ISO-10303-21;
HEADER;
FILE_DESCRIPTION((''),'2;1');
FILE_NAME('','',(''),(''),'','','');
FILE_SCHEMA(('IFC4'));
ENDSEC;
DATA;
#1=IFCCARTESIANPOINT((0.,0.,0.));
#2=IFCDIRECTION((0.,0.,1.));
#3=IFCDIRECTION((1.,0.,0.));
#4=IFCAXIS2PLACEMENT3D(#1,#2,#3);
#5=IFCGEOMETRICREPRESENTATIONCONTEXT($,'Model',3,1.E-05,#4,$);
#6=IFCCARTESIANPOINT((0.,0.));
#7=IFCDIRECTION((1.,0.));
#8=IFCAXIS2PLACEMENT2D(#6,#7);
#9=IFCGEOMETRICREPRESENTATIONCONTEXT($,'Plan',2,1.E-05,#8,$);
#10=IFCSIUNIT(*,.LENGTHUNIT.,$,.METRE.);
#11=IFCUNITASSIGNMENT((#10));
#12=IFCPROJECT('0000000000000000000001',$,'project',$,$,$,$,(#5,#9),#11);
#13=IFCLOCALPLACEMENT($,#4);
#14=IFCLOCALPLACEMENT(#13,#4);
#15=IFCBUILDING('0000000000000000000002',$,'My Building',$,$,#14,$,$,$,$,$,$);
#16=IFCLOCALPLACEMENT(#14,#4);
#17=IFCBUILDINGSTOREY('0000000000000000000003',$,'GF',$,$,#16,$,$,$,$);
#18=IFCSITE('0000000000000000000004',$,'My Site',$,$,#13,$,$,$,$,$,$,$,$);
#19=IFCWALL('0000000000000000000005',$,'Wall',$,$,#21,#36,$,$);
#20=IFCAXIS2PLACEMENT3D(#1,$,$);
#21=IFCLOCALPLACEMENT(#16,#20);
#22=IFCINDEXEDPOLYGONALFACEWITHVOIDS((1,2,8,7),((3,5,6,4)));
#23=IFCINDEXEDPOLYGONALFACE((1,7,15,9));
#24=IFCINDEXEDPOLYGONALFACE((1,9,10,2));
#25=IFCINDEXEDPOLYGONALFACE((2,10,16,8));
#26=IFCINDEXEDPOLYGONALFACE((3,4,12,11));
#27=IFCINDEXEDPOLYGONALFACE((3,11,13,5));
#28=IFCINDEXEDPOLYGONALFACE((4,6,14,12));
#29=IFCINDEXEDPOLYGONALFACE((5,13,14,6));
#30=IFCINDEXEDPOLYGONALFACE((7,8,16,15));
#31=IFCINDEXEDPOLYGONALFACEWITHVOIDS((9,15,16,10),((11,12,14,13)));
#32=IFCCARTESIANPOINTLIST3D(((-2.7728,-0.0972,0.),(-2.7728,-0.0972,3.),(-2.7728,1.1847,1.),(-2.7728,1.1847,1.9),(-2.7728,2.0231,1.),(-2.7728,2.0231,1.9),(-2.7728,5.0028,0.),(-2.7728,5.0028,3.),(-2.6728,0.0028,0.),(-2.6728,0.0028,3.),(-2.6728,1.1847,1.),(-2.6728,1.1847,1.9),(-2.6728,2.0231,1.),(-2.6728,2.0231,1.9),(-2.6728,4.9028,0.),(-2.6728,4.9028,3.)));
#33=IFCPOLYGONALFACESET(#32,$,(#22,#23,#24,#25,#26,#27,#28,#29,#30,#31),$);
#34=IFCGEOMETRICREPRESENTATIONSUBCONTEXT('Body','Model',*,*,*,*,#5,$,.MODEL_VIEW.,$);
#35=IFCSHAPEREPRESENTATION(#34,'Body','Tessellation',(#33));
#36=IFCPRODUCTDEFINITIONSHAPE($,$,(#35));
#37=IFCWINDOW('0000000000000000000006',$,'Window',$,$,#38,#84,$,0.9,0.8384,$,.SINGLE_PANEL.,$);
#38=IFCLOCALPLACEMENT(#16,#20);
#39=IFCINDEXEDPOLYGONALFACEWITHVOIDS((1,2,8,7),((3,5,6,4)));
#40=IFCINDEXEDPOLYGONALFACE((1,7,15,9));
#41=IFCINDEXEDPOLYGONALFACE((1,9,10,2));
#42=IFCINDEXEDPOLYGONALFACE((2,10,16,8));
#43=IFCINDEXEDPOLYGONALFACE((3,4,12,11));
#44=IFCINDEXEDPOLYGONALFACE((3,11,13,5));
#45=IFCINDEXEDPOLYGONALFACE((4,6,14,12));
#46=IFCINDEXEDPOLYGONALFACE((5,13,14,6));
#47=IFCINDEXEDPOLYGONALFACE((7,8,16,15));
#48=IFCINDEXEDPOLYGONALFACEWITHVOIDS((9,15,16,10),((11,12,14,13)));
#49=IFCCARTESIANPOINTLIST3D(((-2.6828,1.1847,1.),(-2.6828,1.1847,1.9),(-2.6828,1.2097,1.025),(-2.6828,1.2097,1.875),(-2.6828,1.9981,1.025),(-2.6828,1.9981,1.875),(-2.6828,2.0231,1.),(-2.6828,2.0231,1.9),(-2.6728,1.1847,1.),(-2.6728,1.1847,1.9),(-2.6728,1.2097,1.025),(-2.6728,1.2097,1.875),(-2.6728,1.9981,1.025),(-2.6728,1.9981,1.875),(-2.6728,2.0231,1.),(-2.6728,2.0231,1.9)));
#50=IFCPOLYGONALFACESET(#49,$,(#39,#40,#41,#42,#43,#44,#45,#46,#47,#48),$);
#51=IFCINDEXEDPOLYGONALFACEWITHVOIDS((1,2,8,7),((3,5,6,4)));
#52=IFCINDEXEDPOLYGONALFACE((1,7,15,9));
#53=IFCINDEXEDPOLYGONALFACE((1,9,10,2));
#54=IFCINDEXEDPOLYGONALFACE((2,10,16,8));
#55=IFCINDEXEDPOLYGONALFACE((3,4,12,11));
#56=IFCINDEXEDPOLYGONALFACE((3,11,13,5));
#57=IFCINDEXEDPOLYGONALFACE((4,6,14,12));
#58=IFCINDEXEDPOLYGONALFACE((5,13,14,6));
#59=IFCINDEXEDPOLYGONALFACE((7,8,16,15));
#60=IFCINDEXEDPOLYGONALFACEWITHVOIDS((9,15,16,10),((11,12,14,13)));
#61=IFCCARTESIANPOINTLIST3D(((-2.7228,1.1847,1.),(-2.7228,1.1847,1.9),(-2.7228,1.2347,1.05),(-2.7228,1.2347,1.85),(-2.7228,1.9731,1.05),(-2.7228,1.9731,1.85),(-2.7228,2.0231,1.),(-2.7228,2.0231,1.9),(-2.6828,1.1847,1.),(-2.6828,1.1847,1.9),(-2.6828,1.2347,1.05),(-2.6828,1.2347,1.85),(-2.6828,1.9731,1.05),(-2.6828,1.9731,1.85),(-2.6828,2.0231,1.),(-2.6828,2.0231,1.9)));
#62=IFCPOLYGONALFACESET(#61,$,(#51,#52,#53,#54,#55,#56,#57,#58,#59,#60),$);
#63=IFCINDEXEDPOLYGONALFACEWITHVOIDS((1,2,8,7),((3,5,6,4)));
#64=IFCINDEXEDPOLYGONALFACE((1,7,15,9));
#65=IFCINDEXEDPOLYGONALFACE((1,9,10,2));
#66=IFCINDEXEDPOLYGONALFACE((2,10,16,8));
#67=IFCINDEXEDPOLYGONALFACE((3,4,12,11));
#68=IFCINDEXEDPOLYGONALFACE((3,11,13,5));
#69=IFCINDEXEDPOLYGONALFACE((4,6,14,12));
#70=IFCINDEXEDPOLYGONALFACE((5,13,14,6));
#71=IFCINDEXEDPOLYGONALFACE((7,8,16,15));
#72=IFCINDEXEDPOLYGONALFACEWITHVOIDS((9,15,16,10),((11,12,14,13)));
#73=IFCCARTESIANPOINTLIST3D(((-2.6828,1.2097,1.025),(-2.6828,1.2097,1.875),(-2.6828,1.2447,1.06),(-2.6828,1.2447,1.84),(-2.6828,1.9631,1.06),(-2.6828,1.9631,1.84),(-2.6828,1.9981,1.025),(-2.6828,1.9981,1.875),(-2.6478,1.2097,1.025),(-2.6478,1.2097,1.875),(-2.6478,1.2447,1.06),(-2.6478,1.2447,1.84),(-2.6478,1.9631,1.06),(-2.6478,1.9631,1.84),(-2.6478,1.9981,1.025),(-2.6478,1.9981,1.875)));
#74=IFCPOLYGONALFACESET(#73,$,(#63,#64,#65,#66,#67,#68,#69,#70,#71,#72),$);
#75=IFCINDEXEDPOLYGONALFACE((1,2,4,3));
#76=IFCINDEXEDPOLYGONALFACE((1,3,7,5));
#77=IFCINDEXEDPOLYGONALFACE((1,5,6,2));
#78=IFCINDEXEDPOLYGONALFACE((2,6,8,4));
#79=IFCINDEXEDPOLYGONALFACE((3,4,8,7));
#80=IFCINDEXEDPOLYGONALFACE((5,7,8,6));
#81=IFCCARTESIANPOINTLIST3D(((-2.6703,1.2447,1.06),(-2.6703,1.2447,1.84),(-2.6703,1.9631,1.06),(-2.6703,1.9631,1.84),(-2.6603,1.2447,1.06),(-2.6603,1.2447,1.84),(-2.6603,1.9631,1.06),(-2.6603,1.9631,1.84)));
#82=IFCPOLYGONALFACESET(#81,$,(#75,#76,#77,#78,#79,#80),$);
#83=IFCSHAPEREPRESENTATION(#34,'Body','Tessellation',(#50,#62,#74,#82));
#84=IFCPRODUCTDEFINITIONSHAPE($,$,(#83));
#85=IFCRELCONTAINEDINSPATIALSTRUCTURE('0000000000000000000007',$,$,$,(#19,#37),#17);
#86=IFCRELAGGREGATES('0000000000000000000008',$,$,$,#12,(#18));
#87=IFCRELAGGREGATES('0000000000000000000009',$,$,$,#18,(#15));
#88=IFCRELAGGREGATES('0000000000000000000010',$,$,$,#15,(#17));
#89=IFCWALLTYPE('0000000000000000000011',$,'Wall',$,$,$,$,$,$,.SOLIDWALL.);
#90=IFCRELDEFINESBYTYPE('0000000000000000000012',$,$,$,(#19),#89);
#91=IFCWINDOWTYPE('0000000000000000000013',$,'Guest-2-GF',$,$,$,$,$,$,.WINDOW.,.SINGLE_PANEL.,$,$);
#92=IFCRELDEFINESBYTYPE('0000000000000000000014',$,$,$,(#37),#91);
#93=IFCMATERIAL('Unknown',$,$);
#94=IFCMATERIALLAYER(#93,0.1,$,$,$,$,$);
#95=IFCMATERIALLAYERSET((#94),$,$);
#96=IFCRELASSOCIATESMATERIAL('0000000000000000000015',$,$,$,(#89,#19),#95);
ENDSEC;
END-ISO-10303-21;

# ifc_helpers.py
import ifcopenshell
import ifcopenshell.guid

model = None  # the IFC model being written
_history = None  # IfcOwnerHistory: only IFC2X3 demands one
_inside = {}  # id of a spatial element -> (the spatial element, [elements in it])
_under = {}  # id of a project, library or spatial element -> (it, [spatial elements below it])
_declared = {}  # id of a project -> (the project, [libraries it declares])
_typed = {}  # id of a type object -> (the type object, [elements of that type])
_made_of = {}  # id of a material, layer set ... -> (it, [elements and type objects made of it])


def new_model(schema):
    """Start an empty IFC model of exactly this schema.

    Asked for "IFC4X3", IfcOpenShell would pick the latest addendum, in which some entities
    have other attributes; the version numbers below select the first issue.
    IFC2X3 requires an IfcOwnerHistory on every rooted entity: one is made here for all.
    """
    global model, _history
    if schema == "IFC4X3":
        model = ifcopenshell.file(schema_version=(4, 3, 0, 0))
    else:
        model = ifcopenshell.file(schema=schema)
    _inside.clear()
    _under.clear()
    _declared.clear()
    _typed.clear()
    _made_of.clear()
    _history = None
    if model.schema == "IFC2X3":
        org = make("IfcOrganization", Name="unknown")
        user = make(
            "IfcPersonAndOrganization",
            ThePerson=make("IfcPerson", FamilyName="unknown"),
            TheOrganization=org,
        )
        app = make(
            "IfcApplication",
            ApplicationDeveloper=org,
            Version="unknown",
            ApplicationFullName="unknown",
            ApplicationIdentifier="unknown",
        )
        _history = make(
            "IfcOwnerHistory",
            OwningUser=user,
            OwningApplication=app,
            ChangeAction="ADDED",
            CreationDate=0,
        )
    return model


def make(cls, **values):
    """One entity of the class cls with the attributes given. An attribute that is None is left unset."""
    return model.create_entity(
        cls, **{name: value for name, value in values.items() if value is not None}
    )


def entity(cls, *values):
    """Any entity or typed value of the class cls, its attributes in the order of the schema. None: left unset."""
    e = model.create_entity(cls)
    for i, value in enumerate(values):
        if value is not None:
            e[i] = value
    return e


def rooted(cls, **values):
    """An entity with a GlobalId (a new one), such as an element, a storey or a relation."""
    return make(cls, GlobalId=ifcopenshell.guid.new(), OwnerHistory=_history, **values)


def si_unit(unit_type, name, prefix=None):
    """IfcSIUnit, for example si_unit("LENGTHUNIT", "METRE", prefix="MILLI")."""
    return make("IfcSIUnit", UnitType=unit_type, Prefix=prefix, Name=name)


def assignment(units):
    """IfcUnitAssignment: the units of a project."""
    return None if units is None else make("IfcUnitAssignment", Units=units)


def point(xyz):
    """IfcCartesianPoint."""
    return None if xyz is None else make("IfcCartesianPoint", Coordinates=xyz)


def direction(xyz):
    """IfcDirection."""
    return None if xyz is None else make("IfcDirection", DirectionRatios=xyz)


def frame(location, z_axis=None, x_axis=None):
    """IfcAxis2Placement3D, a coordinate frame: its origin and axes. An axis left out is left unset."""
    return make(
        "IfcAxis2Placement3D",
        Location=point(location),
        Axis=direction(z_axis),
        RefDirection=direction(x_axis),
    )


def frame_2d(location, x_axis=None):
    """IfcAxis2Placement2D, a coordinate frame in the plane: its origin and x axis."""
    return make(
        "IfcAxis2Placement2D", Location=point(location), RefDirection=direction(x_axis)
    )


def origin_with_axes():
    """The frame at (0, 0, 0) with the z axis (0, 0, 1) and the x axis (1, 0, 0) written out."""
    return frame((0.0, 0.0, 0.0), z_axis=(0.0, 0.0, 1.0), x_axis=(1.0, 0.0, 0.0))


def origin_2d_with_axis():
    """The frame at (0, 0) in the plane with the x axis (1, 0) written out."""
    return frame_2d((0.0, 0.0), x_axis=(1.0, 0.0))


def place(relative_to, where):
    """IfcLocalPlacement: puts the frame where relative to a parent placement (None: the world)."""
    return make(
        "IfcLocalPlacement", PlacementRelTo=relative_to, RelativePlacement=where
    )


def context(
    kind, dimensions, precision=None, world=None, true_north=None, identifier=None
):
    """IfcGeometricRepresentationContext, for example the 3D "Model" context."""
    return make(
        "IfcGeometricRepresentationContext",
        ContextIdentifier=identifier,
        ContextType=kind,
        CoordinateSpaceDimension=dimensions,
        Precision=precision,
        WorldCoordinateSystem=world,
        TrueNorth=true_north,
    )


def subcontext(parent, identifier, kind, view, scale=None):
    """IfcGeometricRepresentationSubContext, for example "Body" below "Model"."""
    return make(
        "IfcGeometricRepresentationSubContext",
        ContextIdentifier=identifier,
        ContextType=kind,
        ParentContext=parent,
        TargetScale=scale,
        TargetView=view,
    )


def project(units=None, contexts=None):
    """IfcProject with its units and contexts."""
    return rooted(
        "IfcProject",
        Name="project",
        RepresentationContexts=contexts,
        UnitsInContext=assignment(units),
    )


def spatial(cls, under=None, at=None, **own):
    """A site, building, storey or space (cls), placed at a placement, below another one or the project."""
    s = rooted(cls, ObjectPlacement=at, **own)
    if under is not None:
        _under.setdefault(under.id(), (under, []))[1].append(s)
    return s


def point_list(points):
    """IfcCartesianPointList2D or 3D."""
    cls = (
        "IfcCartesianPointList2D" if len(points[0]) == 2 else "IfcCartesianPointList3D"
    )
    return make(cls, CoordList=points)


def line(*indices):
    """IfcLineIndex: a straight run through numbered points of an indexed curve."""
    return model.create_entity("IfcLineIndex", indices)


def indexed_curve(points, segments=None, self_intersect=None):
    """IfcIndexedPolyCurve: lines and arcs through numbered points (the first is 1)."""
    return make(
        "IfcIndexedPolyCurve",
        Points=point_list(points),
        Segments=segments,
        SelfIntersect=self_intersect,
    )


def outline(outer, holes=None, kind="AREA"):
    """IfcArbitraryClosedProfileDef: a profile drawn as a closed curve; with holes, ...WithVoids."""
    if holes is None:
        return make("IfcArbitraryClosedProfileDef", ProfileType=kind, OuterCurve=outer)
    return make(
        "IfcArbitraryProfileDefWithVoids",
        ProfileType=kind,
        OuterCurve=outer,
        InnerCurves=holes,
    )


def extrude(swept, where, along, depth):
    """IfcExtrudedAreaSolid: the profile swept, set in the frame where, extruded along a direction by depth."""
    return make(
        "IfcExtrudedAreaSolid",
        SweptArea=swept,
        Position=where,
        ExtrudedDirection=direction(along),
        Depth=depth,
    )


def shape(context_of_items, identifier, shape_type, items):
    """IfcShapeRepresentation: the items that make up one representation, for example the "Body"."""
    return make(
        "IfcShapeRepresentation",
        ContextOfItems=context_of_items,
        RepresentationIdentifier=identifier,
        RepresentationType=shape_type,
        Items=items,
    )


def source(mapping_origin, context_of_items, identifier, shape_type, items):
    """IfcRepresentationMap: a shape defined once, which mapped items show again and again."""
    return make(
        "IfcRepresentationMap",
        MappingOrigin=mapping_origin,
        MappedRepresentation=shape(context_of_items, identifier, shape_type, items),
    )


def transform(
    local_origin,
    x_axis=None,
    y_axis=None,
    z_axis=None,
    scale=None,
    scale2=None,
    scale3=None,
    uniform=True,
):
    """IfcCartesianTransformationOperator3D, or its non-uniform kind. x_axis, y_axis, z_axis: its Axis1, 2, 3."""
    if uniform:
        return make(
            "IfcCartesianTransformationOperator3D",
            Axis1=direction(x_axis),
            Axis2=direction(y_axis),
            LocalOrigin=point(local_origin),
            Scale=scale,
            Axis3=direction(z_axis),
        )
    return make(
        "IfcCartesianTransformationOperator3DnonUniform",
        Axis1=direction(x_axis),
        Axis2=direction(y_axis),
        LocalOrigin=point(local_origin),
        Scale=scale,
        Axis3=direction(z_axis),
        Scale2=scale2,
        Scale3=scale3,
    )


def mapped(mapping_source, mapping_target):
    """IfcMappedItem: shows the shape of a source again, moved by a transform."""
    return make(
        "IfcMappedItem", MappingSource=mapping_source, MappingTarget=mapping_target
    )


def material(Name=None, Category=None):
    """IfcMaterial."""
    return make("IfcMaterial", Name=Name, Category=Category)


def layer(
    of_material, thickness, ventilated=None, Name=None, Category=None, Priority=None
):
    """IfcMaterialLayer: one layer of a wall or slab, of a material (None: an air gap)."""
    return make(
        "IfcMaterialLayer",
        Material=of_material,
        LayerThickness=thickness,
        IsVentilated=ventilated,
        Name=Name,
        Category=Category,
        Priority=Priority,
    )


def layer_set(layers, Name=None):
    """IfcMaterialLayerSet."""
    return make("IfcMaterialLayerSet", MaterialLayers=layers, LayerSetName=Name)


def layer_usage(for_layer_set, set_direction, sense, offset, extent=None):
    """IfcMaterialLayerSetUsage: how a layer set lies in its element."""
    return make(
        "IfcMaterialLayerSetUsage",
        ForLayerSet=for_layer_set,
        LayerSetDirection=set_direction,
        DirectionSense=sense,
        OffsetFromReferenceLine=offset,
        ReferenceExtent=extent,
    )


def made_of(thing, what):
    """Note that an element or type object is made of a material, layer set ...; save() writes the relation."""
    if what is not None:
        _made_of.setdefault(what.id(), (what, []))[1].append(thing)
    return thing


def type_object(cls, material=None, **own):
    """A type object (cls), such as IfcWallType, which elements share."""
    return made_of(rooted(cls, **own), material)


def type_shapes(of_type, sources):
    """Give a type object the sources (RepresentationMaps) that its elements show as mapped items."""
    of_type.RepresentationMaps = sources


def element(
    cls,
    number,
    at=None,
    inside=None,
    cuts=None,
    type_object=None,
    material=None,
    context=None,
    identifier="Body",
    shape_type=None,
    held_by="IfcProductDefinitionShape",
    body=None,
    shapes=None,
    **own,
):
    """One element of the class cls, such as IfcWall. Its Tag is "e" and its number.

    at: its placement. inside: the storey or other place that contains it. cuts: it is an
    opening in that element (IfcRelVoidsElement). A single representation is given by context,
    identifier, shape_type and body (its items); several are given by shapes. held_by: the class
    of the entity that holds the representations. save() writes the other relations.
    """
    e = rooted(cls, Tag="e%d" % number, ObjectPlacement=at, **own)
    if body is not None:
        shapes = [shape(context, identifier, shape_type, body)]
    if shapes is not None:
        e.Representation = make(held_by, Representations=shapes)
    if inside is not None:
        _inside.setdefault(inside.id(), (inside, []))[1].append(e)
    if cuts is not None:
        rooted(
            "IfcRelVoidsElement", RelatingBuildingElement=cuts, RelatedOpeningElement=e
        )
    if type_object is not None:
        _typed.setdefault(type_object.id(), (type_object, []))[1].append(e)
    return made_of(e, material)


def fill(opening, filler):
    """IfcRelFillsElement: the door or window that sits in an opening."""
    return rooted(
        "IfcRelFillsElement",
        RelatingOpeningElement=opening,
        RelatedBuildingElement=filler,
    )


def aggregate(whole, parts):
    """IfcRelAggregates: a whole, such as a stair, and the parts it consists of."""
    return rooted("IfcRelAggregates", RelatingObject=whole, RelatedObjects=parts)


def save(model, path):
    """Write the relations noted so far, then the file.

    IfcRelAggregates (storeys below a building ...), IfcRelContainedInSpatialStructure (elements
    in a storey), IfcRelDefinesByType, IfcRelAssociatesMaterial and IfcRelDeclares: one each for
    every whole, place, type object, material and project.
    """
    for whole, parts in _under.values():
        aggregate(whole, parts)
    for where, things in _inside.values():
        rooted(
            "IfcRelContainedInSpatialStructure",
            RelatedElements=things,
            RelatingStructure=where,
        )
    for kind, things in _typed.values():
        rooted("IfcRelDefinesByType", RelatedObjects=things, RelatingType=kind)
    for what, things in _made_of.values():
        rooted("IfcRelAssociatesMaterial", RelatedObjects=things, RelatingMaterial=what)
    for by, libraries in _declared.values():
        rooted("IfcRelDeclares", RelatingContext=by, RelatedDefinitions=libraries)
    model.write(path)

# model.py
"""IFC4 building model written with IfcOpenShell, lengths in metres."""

from ifc_helpers import new_model, entity, si_unit, frame, origin_with_axes, origin_2d_with_axis, place, context, subcontext, project, spatial, line, indexed_curve, outline, extrude, shape, source, transform, mapped, material, layer, layer_set, layer_usage, type_object, type_shapes, element, fill, save


model = new_model("IFC4")

# Units and contexts
model_context = context("Model", 3, precision=1e-05, world=origin_with_axes())
plan_context = context("Plan", 2, precision=1e-05, world=origin_2d_with_axis())
body_context_1 = subcontext(model_context, "Body", "Model", "MODEL_VIEW")
body_context_2 = subcontext(plan_context, "Body", "Plan", "PLAN_VIEW")
ifc_project = project(units=[si_unit("LENGTHUNIT", "METRE")], contexts=[model_context, plan_context])

# Site, building, storey
site_placement = place(None, origin_with_axes())
site = spatial("IfcSite", under=ifc_project, at=site_placement, Name="My Site")
building_placement = place(site_placement, origin_with_axes())
building = spatial("IfcBuilding", under=site, at=building_placement, Name="My Building")
storey_placement = place(building_placement, origin_with_axes())
storey = spatial("IfcBuildingStorey", under=building, at=storey_placement, Name="GF")

# Shared definitions
ifc_material = material(Name="Unknown")

# Shared definitions
ifc_layer_1 = layer(ifc_material, 0.1)
ifc_layer_set_1 = layer_set([ifc_layer_1])
wall_type = type_object("IfcWallType", Name="Wall", PredefinedType="SOLIDWALL", material=ifc_layer_set_1)

# Wall, opening, window
ifc_layer_usage_1 = layer_usage(ifc_layer_set_1, "AXIS2", "POSITIVE", 0.0)
wall_1_placement = place(storey_placement, frame((-2.7728, 5.0028, 0.0), z_axis=(0.0, 0.0, 1.0), x_axis=(0.0, -1.0, 0.0)))
wall_1 = element("IfcWall", 1, at=wall_1_placement, inside=storey, type_object=wall_type, material=ifc_layer_usage_1, Name="Wall", context=body_context_1, shape_type="SweptSolid", body=[
    extrude(outline(indexed_curve([(0.0, 0.0), (0.1, 0.1), (5.0, 0.1), (5.1, 0.0)], segments=[line(1, 2, 3, 4, 1)])), origin_with_axes(), (0.0, 0.0, 1.0), 3.0),
])
shared_shape_1 = source(origin_with_axes(), body_context_1, "Body", "SweptSolid", [
    extrude(outline(indexed_curve([(0.0, 0.0), (0.8384, 0.0), (0.8384, 0.9), (0.0, 0.9)], segments=[line(1, 2, 3, 4, 1)])), frame((0.0, -0.6, 0.0), z_axis=(0.0, -1.0, 0.0), x_axis=(1.0, 0.0, 0.0)), (0.0, 0.0, -1.0), 1.2),
])
opening_1_placement = place(wall_1_placement, frame((2.9797, 0.0, 1.0), z_axis=(0.0, 0.0, 1.0), x_axis=(1.0, 0.0, 0.0)))
opening_1 = element("IfcOpeningElement", 2, at=opening_1_placement, cuts=wall_1, PredefinedType="OPENING", context=body_context_1, shape_type="MappedRepresentation", body=[
    mapped(shared_shape_1, transform((0.0, 0.0, 0.0), x_axis=(1.0, 0.0, 0.0), y_axis=(0.0, 1.0, 0.0), z_axis=(0.0, 0.0, 1.0), scale=1.0)),
])
window_type_1 = type_object("IfcWindowType", Name="Guest-2-GF", PartitioningType="SINGLE_PANEL", PredefinedType="WINDOW")
shared_shape_2 = source(origin_with_axes(), body_context_1, "Body", "SweptSolid", [
    extrude(outline(indexed_curve([(0.0, 0.0), (0.8384, 0.0), (0.8384, 0.9), (0.0, 0.9)], segments=[line(1, 2, 3, 4, 1)]), holes=[indexed_curve([(0.025, 0.025), (0.8134, 0.025), (0.8134, 0.875), (0.025, 0.875)], segments=[line(1, 2, 3, 4, 1)])]), frame((0.0, 0.09, 0.0), z_axis=(0.0, -1.0, 0.0), x_axis=(1.0, 0.0, 0.0)), (0.0, 0.0, -1.0), 0.01),
    extrude(outline(indexed_curve([(0.0, 0.0), (0.8384, 0.0), (0.8384, 0.9), (0.0, 0.9)], segments=[line(1, 2, 3, 4, 1)]), holes=[indexed_curve([(0.05, 0.05), (0.7884, 0.05), (0.7884, 0.85), (0.05, 0.85)], segments=[line(1, 2, 3, 4, 1)])]), frame((0.0, 0.05, 0.0), z_axis=(0.0, -1.0, 0.0), x_axis=(1.0, 0.0, 0.0)), (0.0, 0.0, -1.0), 0.04),
    extrude(outline(indexed_curve([(0.0, 0.0), (0.7884, 0.0), (0.7884, 0.85), (0.0, 0.85)], segments=[line(1, 2, 3, 4, 1)]), holes=[indexed_curve([(0.035, 0.035), (0.7534, 0.035), (0.7534, 0.815), (0.035, 0.815)], segments=[line(1, 2, 3, 4, 1)])]), frame((0.025, 0.09, 0.025), z_axis=(0.0, -1.0, 0.0), x_axis=(1.0, 0.0, 0.0)), (0.0, 0.0, -1.0), 0.035),
    extrude(outline(indexed_curve([(0.035, 0.035), (0.7534, 0.035), (0.7534, 0.815), (0.035, 0.815)], segments=[line(1, 2, 3, 4, 1)])), frame((0.025, 0.1025, 0.025), z_axis=(0.0, -1.0, 0.0), x_axis=(1.0, 0.0, 0.0)), (0.0, 0.0, -1.0), 0.01),
])
shared_shape_3 = source(origin_with_axes(), body_context_2, "Body", "Curve2D", [
    entity("IfcIndexedPolyCurve", entity("IfcCartesianPointList2D", [[0.05, 0.05], [0.7884, 0.05]])),
    entity("IfcIndexedPolyCurve", entity("IfcCartesianPointList2D", [[0.0, 0.1], [0.025, 0.1], [0.025, 0.09], [0.05, 0.09], [0.05, 0.05], [0.0, 0.05]]), [entity("IfcLineIndex", [1, 2, 3, 4, 5, 6, 1])]),
    entity("IfcIndexedPolyCurve", entity("IfcCartesianPointList2D", [[0.8384, 0.1], [0.8134, 0.1], [0.8134, 0.09], [0.7884, 0.09], [0.7884, 0.05], [0.8384, 0.05]]), [entity("IfcLineIndex", [1, 2, 3, 4, 5, 6, 1])]),
    entity("IfcIndexedPolyCurve", entity("IfcCartesianPointList2D", [[0.025, 0.09], [0.06, 0.09], [0.06, 0.125], [0.025, 0.125]]), [entity("IfcLineIndex", [1, 2, 3, 4, 1])]),
    entity("IfcIndexedPolyCurve", entity("IfcCartesianPointList2D", [[0.8134, 0.09], [0.7784, 0.09], [0.7784, 0.125], [0.8134, 0.125]]), [entity("IfcLineIndex", [1, 2, 3, 4, 1])]),
    entity("IfcIndexedPolyCurve", entity("IfcCartesianPointList2D", [[0.06, 0.09], [0.7784, 0.09]])),
    entity("IfcIndexedPolyCurve", entity("IfcCartesianPointList2D", [[0.06, 0.125], [0.7784, 0.125]])),
    entity("IfcIndexedPolyCurve", entity("IfcCartesianPointList2D", [[0.06, 0.1075], [0.7784, 0.1075]])),
])
type_shapes(window_type_1, [shared_shape_2, shared_shape_3])
window_1_placement = place(opening_1_placement, frame((0.0, 0.0, 0.0), z_axis=(0.0, 0.0, 1.0), x_axis=(1.0, 0.0, 0.0)))
window_1 = element("IfcWindow", 3, at=window_1_placement, inside=storey, type_object=window_type_1, Name="Window", OverallHeight=0.9, OverallWidth=0.8384, PartitioningType="SINGLE_PANEL", shapes=[
    shape(body_context_1, "Body", "MappedRepresentation", [mapped(shared_shape_2, transform((0.0, 0.0, 0.0), x_axis=(1.0, 0.0, 0.0), y_axis=(0.0, 1.0, 0.0), z_axis=(0.0, 0.0, 1.0), scale=1.0))]),
    shape(body_context_2, "Body", "MappedRepresentation", [mapped(shared_shape_3, transform((0.0, 0.0, 0.0), x_axis=(1.0, 0.0, 0.0), y_axis=(0.0, 1.0, 0.0), z_axis=(0.0, 0.0, 1.0), scale=1.0))]),
])
fill(opening_1, window_1)

save(model, "model.ifc")
